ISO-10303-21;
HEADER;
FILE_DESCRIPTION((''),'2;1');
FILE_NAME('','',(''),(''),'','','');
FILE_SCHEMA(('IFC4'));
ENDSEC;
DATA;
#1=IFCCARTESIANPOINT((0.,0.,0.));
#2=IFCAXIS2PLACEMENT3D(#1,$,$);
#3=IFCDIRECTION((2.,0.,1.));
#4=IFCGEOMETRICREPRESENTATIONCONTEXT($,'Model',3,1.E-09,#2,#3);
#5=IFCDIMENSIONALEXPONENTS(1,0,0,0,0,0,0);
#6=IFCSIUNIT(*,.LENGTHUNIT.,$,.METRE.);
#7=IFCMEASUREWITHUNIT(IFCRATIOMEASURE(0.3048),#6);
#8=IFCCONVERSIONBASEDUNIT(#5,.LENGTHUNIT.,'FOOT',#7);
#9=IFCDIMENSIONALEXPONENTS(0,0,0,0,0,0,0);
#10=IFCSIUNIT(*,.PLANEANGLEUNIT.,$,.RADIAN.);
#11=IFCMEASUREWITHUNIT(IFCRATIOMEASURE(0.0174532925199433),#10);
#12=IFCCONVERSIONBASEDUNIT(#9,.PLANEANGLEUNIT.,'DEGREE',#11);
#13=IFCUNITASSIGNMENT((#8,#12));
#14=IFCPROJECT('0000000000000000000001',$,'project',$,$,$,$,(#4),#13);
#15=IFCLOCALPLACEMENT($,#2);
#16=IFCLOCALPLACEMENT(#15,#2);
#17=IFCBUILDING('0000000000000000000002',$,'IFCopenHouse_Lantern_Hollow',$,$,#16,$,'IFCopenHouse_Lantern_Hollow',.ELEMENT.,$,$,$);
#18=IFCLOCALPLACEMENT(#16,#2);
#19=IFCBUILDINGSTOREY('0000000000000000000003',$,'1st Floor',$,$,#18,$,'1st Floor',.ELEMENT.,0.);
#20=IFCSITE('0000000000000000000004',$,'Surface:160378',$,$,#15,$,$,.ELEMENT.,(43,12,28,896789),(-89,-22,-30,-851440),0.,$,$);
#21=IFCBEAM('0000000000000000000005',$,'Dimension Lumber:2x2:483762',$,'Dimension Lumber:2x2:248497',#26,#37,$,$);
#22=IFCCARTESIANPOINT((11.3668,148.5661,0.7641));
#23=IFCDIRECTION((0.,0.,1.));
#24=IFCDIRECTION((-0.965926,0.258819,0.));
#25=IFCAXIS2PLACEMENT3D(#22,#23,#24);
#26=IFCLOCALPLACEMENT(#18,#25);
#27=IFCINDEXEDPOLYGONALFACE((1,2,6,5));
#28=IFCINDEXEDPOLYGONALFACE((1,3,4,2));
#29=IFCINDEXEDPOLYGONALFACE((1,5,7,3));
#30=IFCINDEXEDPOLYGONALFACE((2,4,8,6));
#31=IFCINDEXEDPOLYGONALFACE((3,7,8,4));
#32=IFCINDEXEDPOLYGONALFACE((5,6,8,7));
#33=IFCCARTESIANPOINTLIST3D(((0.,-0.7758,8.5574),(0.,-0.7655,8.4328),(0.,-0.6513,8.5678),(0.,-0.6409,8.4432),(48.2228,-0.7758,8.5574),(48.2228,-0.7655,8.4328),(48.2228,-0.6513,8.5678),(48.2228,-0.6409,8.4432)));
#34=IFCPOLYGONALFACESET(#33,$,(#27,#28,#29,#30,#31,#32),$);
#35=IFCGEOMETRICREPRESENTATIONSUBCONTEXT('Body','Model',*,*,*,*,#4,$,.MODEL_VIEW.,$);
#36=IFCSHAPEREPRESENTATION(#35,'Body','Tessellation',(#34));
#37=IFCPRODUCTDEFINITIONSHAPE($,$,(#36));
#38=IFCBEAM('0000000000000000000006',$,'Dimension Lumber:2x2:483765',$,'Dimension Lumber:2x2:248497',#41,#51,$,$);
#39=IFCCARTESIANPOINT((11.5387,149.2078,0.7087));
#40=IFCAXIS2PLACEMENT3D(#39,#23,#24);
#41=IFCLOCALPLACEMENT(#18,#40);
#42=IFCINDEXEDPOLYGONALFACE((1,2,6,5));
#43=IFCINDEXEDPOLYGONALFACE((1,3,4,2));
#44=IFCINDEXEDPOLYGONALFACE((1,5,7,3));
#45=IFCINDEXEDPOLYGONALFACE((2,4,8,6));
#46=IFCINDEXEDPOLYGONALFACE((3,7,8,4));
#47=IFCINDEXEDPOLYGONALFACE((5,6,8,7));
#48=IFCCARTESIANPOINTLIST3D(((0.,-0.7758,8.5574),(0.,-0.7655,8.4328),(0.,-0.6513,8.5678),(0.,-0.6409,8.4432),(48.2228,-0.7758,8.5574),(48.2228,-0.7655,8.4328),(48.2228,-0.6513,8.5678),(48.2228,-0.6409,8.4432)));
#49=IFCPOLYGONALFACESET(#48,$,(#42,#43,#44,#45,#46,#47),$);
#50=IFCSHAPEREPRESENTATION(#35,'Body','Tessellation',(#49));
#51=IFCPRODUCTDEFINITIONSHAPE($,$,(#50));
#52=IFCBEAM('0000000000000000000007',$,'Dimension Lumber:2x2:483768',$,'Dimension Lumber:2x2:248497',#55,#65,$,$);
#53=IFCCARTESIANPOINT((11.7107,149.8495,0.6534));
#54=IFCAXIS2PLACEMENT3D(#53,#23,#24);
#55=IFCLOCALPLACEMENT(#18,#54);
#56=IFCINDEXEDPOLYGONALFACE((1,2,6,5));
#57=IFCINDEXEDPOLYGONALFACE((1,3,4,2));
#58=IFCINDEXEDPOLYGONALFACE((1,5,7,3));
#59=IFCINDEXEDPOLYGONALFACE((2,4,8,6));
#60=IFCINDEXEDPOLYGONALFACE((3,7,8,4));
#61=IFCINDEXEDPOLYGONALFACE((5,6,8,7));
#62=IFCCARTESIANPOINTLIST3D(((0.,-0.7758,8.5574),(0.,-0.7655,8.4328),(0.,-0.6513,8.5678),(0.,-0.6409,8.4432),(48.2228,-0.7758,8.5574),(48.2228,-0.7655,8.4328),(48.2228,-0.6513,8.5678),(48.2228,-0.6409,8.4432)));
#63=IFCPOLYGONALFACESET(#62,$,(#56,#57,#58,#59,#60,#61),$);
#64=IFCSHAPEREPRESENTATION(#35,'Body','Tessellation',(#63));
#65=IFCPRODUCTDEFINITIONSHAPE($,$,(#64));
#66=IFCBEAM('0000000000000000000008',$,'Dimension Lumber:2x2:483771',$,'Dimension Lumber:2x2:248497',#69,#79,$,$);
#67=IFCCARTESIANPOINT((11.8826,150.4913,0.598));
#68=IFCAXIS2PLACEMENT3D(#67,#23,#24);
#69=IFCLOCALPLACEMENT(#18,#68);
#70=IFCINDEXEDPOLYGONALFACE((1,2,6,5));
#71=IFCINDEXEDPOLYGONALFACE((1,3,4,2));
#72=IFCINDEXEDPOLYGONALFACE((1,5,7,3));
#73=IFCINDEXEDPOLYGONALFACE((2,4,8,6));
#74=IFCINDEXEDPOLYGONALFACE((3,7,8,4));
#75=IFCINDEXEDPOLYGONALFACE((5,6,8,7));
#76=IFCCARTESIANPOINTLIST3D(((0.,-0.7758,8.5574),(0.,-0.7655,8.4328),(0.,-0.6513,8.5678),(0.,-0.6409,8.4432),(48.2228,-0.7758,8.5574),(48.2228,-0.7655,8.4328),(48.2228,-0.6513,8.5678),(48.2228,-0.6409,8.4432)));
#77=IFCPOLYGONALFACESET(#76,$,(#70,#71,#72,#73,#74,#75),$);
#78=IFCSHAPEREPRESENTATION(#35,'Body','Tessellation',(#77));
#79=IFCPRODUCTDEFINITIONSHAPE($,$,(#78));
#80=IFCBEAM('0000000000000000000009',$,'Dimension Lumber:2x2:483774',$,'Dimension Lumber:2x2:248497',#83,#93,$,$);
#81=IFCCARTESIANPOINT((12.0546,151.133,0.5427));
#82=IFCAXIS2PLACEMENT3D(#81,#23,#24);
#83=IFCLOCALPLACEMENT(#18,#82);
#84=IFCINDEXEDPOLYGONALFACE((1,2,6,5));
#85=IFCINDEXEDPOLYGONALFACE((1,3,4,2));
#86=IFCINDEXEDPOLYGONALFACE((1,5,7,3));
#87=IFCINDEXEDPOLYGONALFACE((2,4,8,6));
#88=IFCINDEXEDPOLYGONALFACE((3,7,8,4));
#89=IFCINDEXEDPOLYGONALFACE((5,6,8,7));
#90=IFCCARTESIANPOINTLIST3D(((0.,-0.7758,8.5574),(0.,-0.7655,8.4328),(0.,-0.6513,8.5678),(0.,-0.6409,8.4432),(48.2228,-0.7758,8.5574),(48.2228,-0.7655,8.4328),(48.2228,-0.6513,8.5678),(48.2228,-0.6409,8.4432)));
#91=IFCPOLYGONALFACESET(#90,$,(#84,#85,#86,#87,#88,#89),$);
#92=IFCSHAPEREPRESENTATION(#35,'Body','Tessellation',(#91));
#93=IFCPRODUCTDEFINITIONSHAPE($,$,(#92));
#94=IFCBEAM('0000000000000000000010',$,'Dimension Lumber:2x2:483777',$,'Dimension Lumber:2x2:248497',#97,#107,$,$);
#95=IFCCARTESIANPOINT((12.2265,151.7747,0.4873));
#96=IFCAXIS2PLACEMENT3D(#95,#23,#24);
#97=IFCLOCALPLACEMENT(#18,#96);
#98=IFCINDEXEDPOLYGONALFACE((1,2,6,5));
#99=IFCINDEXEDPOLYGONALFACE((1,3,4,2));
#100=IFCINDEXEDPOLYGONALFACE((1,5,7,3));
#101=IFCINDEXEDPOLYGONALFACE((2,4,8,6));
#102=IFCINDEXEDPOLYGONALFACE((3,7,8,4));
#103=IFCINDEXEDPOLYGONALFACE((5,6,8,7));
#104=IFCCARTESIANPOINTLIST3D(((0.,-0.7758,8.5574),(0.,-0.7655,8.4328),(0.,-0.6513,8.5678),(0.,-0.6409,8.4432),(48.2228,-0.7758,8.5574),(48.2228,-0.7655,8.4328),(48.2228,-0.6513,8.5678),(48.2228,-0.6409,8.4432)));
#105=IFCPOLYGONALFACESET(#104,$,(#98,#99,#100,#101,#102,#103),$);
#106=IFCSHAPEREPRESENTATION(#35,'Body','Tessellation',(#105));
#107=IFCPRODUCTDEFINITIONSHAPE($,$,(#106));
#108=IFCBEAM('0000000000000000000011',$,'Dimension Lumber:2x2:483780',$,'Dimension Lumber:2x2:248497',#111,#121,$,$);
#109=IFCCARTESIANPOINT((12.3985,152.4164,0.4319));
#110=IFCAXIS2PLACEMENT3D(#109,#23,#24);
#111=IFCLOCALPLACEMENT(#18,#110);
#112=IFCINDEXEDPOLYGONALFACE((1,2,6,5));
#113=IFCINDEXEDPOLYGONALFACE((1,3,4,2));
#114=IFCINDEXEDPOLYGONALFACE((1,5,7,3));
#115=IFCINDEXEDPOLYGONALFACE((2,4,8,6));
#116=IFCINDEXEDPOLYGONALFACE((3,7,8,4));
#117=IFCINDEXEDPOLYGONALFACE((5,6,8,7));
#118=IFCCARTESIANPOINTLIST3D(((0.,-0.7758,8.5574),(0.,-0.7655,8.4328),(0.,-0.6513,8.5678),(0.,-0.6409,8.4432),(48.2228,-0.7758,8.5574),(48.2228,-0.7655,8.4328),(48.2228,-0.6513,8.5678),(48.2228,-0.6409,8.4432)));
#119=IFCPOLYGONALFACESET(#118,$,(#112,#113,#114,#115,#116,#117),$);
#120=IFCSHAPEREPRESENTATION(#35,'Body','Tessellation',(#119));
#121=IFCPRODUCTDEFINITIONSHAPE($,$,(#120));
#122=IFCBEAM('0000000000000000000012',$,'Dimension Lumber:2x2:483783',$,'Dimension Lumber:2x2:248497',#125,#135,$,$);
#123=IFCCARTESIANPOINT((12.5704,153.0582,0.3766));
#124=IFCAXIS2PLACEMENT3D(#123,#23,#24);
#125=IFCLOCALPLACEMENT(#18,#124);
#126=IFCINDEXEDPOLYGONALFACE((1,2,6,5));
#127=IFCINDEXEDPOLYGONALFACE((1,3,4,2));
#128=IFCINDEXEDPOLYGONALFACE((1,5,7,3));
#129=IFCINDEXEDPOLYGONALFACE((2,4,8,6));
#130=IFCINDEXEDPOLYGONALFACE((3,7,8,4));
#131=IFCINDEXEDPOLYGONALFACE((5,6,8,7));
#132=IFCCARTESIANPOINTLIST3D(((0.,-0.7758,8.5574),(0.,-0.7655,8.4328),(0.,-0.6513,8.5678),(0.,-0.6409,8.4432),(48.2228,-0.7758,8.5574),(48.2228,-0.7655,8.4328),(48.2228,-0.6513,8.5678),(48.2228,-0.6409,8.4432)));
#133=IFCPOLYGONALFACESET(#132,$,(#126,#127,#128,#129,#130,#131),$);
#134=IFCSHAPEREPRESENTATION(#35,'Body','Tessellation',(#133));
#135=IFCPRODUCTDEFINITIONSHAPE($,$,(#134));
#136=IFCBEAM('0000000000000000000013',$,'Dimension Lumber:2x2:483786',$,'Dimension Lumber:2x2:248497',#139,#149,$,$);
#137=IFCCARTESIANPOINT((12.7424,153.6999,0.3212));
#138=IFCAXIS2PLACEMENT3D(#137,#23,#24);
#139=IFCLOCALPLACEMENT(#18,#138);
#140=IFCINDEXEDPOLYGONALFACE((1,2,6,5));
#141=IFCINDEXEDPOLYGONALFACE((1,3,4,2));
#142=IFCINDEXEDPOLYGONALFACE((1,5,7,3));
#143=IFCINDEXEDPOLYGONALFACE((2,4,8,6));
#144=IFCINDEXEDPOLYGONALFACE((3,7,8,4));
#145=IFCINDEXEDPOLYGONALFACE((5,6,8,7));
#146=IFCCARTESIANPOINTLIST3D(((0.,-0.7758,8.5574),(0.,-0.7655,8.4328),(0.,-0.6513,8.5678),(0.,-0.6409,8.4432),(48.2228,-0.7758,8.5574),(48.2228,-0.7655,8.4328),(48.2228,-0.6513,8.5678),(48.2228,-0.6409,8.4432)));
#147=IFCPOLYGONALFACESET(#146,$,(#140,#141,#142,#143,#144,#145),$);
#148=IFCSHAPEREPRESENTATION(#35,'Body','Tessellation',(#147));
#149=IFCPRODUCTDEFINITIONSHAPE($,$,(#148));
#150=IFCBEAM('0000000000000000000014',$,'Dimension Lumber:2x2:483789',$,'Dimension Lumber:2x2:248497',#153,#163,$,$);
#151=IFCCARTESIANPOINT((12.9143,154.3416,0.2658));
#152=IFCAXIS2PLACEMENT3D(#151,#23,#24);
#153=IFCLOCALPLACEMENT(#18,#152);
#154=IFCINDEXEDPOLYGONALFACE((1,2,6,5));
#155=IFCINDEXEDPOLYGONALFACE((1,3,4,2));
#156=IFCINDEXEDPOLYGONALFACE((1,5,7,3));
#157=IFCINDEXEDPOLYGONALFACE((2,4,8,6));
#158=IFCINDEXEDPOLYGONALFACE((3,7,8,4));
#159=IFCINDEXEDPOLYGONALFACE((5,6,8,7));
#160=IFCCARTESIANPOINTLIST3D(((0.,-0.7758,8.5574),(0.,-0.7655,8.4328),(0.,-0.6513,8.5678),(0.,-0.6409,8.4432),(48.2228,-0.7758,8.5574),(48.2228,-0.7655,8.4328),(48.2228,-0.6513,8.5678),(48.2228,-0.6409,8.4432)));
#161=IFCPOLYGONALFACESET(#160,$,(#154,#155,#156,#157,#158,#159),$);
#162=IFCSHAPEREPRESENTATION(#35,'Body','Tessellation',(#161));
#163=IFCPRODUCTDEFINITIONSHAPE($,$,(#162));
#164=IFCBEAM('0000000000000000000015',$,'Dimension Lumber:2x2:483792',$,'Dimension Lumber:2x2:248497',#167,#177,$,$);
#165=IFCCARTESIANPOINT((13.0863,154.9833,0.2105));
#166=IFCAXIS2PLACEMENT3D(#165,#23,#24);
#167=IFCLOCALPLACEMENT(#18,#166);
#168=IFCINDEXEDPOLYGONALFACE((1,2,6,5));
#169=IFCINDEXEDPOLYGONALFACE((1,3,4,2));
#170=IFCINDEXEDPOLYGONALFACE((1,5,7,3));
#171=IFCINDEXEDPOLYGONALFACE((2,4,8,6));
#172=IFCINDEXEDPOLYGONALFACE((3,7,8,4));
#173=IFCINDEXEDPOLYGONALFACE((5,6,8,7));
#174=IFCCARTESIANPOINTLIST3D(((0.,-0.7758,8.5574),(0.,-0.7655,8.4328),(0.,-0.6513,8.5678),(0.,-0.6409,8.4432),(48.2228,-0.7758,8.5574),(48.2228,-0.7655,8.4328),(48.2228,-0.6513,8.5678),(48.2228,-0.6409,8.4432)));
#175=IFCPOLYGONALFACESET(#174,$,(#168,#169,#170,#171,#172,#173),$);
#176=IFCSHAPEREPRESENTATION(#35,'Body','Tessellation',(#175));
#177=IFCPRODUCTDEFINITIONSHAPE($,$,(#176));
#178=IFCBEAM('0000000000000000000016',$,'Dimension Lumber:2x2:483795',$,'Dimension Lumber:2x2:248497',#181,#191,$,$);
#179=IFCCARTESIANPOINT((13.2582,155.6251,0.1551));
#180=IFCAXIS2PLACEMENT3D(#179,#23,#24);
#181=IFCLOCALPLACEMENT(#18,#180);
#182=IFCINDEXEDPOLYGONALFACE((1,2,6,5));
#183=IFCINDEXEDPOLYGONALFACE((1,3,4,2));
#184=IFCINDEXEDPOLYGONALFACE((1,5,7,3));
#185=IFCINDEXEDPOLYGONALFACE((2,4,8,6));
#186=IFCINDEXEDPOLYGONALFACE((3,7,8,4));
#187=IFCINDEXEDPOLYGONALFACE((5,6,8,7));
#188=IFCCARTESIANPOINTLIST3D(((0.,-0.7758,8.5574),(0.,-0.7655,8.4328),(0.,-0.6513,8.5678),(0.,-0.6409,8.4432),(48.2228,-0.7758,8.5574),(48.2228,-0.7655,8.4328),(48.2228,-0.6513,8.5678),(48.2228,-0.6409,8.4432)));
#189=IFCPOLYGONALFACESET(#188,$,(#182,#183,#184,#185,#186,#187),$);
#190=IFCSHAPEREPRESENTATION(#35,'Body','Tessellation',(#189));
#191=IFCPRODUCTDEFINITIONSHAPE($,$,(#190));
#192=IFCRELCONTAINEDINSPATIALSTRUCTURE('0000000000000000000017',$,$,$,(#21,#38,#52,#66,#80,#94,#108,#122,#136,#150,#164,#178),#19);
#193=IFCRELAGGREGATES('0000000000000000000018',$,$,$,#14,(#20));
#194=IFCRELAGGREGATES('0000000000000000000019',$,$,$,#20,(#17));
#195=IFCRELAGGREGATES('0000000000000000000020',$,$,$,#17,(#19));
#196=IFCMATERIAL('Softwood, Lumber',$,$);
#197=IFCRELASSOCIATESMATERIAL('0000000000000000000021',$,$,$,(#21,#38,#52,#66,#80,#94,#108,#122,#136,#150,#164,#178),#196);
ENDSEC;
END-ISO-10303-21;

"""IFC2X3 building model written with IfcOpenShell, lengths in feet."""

from ifc_helpers import new_model, entity, si_unit, converted_unit, direction, frame, frame_2d, origin, place, context, subcontext, project, spatial, rectangle, extrude, material, element, save


model = new_model("IFC2X3")

# Units and contexts
model_context = context("Model", 3, precision=1e-09, world=origin(), true_north=direction((2.0, 0.0, 1.0)))
body_context = subcontext(model_context, "Body", "Model", "MODEL_VIEW")
ifc_project = project(units=[converted_unit("LENGTHUNIT", "FOOT", entity("IfcRatioMeasure", 0.3048), si_unit("LENGTHUNIT", "METRE"), dimensions=[1, 0, 0, 0, 0, 0, 0]), converted_unit("PLANEANGLEUNIT", "DEGREE", entity("IfcRatioMeasure", 0.0174532925199433), si_unit("PLANEANGLEUNIT", "RADIAN"), dimensions=[0, 0, 0, 0, 0, 0, 0])], contexts=[model_context])

# Site, building, storey
site_placement = place(None, origin())
site = spatial("IfcSite", under=ifc_project, at=site_placement, Name="Surface:160378", CompositionType="ELEMENT", RefLatitude=(43, 12, 28, 896789), RefLongitude=(-89, -22, -30, -851440), RefElevation=0.0)
building_placement = place(site_placement, origin())
building = spatial("IfcBuilding", under=site, at=building_placement, Name="IFCopenHouse_Lantern_Hollow", LongName="IFCopenHouse_Lantern_Hollow", CompositionType="ELEMENT")
storey_placement = place(building_placement, origin())
storey = spatial("IfcBuildingStorey", under=building, at=storey_placement, Name="1st Floor", LongName="1st Floor", CompositionType="ELEMENT", Elevation=0.0)

# Beams
ifc_material = material(Name="Softwood, Lumber")
beam_1_placement = place(storey_placement, frame((11.3668, 148.5661, 0.7641), z_axis=(0.0, 0.0, 1.0), x_axis=(-0.965926, 0.258819, 0.0)))
element("IfcBeam", 1, at=beam_1_placement, inside=storey, material=ifc_material, Name="Dimension Lumber:2x2:483762", ObjectType="Dimension Lumber:2x2:248497", context=body_context, shape_type="SweptSolid", body=[
    extrude(rectangle(XDim=0.125, YDim=0.125, at=frame_2d((0.0, 0.0), x_axis=(0.0, 1.0))), frame((0.0, -0.7084, 8.5003), z_axis=(1.0, 0.0, 0.0), x_axis=(0.0, -0.996546, -0.083045)), (0.0, 0.0, 1.0), 48.2228),
])
beam_2_placement = place(storey_placement, frame((11.5387, 149.2078, 0.7087), z_axis=(0.0, 0.0, 1.0), x_axis=(-0.965926, 0.258819, 0.0)))
element("IfcBeam", 2, at=beam_2_placement, inside=storey, material=ifc_material, Name="Dimension Lumber:2x2:483765", ObjectType="Dimension Lumber:2x2:248497", context=body_context, shape_type="SweptSolid", body=[
    extrude(rectangle(XDim=0.125, YDim=0.125, at=frame_2d((0.0, 0.0), x_axis=(0.0, 1.0))), frame((0.0, -0.7084, 8.5003), z_axis=(1.0, 0.0, 0.0), x_axis=(0.0, -0.996546, -0.083045)), (0.0, 0.0, 1.0), 48.2228),
])
beam_3_placement = place(storey_placement, frame((11.7107, 149.8495, 0.6534), z_axis=(0.0, 0.0, 1.0), x_axis=(-0.965926, 0.258819, 0.0)))
element("IfcBeam", 3, at=beam_3_placement, inside=storey, material=ifc_material, Name="Dimension Lumber:2x2:483768", ObjectType="Dimension Lumber:2x2:248497", context=body_context, shape_type="SweptSolid", body=[
    extrude(rectangle(XDim=0.125, YDim=0.125, at=frame_2d((0.0, 0.0), x_axis=(0.0, 1.0))), frame((0.0, -0.7084, 8.5003), z_axis=(1.0, 0.0, 0.0), x_axis=(0.0, -0.996546, -0.083045)), (0.0, 0.0, 1.0), 48.2228),
])
beam_4_placement = place(storey_placement, frame((11.8826, 150.4913, 0.598), z_axis=(0.0, 0.0, 1.0), x_axis=(-0.965926, 0.258819, 0.0)))
element("IfcBeam", 4, at=beam_4_placement, inside=storey, material=ifc_material, Name="Dimension Lumber:2x2:483771", ObjectType="Dimension Lumber:2x2:248497", context=body_context, shape_type="SweptSolid", body=[
    extrude(rectangle(XDim=0.125, YDim=0.125, at=frame_2d((0.0, 0.0), x_axis=(0.0, 1.0))), frame((0.0, -0.7084, 8.5003), z_axis=(1.0, 0.0, 0.0), x_axis=(0.0, -0.996546, -0.083045)), (0.0, 0.0, 1.0), 48.2228),
])
beam_5_placement = place(storey_placement, frame((12.0546, 151.133, 0.5427), z_axis=(0.0, 0.0, 1.0), x_axis=(-0.965926, 0.258819, 0.0)))
element("IfcBeam", 5, at=beam_5_placement, inside=storey, material=ifc_material, Name="Dimension Lumber:2x2:483774", ObjectType="Dimension Lumber:2x2:248497", context=body_context, shape_type="SweptSolid", body=[
    extrude(rectangle(XDim=0.125, YDim=0.125, at=frame_2d((0.0, 0.0), x_axis=(0.0, 1.0))), frame((0.0, -0.7084, 8.5003), z_axis=(1.0, 0.0, 0.0), x_axis=(0.0, -0.996546, -0.083045)), (0.0, 0.0, 1.0), 48.2228),
])
beam_6_placement = place(storey_placement, frame((12.2265, 151.7747, 0.4873), z_axis=(0.0, 0.0, 1.0), x_axis=(-0.965926, 0.258819, 0.0)))
element("IfcBeam", 6, at=beam_6_placement, inside=storey, material=ifc_material, Name="Dimension Lumber:2x2:483777", ObjectType="Dimension Lumber:2x2:248497", context=body_context, shape_type="SweptSolid", body=[
    extrude(rectangle(XDim=0.125, YDim=0.125, at=frame_2d((0.0, 0.0), x_axis=(0.0, 1.0))), frame((0.0, -0.7084, 8.5003), z_axis=(1.0, 0.0, 0.0), x_axis=(0.0, -0.996546, -0.083045)), (0.0, 0.0, 1.0), 48.2228),
])
beam_7_placement = place(storey_placement, frame((12.3985, 152.4164, 0.4319), z_axis=(0.0, 0.0, 1.0), x_axis=(-0.965926, 0.258819, 0.0)))
element("IfcBeam", 7, at=beam_7_placement, inside=storey, material=ifc_material, Name="Dimension Lumber:2x2:483780", ObjectType="Dimension Lumber:2x2:248497", context=body_context, shape_type="SweptSolid", body=[
    extrude(rectangle(XDim=0.125, YDim=0.125, at=frame_2d((0.0, 0.0), x_axis=(0.0, 1.0))), frame((0.0, -0.7084, 8.5003), z_axis=(1.0, 0.0, 0.0), x_axis=(0.0, -0.996546, -0.083045)), (0.0, 0.0, 1.0), 48.2228),
])
beam_8_placement = place(storey_placement, frame((12.5704, 153.0582, 0.3766), z_axis=(0.0, 0.0, 1.0), x_axis=(-0.965926, 0.258819, 0.0)))
element("IfcBeam", 8, at=beam_8_placement, inside=storey, material=ifc_material, Name="Dimension Lumber:2x2:483783", ObjectType="Dimension Lumber:2x2:248497", context=body_context, shape_type="SweptSolid", body=[
    extrude(rectangle(XDim=0.125, YDim=0.125, at=frame_2d((0.0, 0.0), x_axis=(0.0, 1.0))), frame((0.0, -0.7084, 8.5003), z_axis=(1.0, 0.0, 0.0), x_axis=(0.0, -0.996546, -0.083045)), (0.0, 0.0, 1.0), 48.2228),
])
beam_9_placement = place(storey_placement, frame((12.7424, 153.6999, 0.3212), z_axis=(0.0, 0.0, 1.0), x_axis=(-0.965926, 0.258819, 0.0)))
element("IfcBeam", 9, at=beam_9_placement, inside=storey, material=ifc_material, Name="Dimension Lumber:2x2:483786", ObjectType="Dimension Lumber:2x2:248497", context=body_context, shape_type="SweptSolid", body=[
    extrude(rectangle(XDim=0.125, YDim=0.125, at=frame_2d((0.0, 0.0), x_axis=(0.0, 1.0))), frame((0.0, -0.7084, 8.5003), z_axis=(1.0, 0.0, 0.0), x_axis=(0.0, -0.996546, -0.083045)), (0.0, 0.0, 1.0), 48.2228),
])
beam_10_placement = place(storey_placement, frame((12.9143, 154.3416, 0.2658), z_axis=(0.0, 0.0, 1.0), x_axis=(-0.965926, 0.258819, 0.0)))
element("IfcBeam", 10, at=beam_10_placement, inside=storey, material=ifc_material, Name="Dimension Lumber:2x2:483789", ObjectType="Dimension Lumber:2x2:248497", context=body_context, shape_type="SweptSolid", body=[
    extrude(rectangle(XDim=0.125, YDim=0.125, at=frame_2d((0.0, 0.0), x_axis=(0.0, 1.0))), frame((0.0, -0.7084, 8.5003), z_axis=(1.0, 0.0, 0.0), x_axis=(0.0, -0.996546, -0.083045)), (0.0, 0.0, 1.0), 48.2228),
])
beam_11_placement = place(storey_placement, frame((13.0863, 154.9833, 0.2105), z_axis=(0.0, 0.0, 1.0), x_axis=(-0.965926, 0.258819, 0.0)))
element("IfcBeam", 11, at=beam_11_placement, inside=storey, material=ifc_material, Name="Dimension Lumber:2x2:483792", ObjectType="Dimension Lumber:2x2:248497", context=body_context, shape_type="SweptSolid", body=[
    extrude(rectangle(XDim=0.125, YDim=0.125, at=frame_2d((0.0, 0.0), x_axis=(0.0, 1.0))), frame((0.0, -0.7084, 8.5003), z_axis=(1.0, 0.0, 0.0), x_axis=(0.0, -0.996546, -0.083045)), (0.0, 0.0, 1.0), 48.2228),
])
beam_12_placement = place(storey_placement, frame((13.2582, 155.6251, 0.1551), z_axis=(0.0, 0.0, 1.0), x_axis=(-0.965926, 0.258819, 0.0)))
element("IfcBeam", 12, at=beam_12_placement, inside=storey, material=ifc_material, Name="Dimension Lumber:2x2:483795", ObjectType="Dimension Lumber:2x2:248497", context=body_context, shape_type="SweptSolid", body=[
    extrude(rectangle(XDim=0.125, YDim=0.125, at=frame_2d((0.0, 0.0), x_axis=(0.0, 1.0))), frame((0.0, -0.7084, 8.5003), z_axis=(1.0, 0.0, 0.0), x_axis=(0.0, -0.996546, -0.083045)), (0.0, 0.0, 1.0), 48.2228),
])

save(model, "model.ifc")
